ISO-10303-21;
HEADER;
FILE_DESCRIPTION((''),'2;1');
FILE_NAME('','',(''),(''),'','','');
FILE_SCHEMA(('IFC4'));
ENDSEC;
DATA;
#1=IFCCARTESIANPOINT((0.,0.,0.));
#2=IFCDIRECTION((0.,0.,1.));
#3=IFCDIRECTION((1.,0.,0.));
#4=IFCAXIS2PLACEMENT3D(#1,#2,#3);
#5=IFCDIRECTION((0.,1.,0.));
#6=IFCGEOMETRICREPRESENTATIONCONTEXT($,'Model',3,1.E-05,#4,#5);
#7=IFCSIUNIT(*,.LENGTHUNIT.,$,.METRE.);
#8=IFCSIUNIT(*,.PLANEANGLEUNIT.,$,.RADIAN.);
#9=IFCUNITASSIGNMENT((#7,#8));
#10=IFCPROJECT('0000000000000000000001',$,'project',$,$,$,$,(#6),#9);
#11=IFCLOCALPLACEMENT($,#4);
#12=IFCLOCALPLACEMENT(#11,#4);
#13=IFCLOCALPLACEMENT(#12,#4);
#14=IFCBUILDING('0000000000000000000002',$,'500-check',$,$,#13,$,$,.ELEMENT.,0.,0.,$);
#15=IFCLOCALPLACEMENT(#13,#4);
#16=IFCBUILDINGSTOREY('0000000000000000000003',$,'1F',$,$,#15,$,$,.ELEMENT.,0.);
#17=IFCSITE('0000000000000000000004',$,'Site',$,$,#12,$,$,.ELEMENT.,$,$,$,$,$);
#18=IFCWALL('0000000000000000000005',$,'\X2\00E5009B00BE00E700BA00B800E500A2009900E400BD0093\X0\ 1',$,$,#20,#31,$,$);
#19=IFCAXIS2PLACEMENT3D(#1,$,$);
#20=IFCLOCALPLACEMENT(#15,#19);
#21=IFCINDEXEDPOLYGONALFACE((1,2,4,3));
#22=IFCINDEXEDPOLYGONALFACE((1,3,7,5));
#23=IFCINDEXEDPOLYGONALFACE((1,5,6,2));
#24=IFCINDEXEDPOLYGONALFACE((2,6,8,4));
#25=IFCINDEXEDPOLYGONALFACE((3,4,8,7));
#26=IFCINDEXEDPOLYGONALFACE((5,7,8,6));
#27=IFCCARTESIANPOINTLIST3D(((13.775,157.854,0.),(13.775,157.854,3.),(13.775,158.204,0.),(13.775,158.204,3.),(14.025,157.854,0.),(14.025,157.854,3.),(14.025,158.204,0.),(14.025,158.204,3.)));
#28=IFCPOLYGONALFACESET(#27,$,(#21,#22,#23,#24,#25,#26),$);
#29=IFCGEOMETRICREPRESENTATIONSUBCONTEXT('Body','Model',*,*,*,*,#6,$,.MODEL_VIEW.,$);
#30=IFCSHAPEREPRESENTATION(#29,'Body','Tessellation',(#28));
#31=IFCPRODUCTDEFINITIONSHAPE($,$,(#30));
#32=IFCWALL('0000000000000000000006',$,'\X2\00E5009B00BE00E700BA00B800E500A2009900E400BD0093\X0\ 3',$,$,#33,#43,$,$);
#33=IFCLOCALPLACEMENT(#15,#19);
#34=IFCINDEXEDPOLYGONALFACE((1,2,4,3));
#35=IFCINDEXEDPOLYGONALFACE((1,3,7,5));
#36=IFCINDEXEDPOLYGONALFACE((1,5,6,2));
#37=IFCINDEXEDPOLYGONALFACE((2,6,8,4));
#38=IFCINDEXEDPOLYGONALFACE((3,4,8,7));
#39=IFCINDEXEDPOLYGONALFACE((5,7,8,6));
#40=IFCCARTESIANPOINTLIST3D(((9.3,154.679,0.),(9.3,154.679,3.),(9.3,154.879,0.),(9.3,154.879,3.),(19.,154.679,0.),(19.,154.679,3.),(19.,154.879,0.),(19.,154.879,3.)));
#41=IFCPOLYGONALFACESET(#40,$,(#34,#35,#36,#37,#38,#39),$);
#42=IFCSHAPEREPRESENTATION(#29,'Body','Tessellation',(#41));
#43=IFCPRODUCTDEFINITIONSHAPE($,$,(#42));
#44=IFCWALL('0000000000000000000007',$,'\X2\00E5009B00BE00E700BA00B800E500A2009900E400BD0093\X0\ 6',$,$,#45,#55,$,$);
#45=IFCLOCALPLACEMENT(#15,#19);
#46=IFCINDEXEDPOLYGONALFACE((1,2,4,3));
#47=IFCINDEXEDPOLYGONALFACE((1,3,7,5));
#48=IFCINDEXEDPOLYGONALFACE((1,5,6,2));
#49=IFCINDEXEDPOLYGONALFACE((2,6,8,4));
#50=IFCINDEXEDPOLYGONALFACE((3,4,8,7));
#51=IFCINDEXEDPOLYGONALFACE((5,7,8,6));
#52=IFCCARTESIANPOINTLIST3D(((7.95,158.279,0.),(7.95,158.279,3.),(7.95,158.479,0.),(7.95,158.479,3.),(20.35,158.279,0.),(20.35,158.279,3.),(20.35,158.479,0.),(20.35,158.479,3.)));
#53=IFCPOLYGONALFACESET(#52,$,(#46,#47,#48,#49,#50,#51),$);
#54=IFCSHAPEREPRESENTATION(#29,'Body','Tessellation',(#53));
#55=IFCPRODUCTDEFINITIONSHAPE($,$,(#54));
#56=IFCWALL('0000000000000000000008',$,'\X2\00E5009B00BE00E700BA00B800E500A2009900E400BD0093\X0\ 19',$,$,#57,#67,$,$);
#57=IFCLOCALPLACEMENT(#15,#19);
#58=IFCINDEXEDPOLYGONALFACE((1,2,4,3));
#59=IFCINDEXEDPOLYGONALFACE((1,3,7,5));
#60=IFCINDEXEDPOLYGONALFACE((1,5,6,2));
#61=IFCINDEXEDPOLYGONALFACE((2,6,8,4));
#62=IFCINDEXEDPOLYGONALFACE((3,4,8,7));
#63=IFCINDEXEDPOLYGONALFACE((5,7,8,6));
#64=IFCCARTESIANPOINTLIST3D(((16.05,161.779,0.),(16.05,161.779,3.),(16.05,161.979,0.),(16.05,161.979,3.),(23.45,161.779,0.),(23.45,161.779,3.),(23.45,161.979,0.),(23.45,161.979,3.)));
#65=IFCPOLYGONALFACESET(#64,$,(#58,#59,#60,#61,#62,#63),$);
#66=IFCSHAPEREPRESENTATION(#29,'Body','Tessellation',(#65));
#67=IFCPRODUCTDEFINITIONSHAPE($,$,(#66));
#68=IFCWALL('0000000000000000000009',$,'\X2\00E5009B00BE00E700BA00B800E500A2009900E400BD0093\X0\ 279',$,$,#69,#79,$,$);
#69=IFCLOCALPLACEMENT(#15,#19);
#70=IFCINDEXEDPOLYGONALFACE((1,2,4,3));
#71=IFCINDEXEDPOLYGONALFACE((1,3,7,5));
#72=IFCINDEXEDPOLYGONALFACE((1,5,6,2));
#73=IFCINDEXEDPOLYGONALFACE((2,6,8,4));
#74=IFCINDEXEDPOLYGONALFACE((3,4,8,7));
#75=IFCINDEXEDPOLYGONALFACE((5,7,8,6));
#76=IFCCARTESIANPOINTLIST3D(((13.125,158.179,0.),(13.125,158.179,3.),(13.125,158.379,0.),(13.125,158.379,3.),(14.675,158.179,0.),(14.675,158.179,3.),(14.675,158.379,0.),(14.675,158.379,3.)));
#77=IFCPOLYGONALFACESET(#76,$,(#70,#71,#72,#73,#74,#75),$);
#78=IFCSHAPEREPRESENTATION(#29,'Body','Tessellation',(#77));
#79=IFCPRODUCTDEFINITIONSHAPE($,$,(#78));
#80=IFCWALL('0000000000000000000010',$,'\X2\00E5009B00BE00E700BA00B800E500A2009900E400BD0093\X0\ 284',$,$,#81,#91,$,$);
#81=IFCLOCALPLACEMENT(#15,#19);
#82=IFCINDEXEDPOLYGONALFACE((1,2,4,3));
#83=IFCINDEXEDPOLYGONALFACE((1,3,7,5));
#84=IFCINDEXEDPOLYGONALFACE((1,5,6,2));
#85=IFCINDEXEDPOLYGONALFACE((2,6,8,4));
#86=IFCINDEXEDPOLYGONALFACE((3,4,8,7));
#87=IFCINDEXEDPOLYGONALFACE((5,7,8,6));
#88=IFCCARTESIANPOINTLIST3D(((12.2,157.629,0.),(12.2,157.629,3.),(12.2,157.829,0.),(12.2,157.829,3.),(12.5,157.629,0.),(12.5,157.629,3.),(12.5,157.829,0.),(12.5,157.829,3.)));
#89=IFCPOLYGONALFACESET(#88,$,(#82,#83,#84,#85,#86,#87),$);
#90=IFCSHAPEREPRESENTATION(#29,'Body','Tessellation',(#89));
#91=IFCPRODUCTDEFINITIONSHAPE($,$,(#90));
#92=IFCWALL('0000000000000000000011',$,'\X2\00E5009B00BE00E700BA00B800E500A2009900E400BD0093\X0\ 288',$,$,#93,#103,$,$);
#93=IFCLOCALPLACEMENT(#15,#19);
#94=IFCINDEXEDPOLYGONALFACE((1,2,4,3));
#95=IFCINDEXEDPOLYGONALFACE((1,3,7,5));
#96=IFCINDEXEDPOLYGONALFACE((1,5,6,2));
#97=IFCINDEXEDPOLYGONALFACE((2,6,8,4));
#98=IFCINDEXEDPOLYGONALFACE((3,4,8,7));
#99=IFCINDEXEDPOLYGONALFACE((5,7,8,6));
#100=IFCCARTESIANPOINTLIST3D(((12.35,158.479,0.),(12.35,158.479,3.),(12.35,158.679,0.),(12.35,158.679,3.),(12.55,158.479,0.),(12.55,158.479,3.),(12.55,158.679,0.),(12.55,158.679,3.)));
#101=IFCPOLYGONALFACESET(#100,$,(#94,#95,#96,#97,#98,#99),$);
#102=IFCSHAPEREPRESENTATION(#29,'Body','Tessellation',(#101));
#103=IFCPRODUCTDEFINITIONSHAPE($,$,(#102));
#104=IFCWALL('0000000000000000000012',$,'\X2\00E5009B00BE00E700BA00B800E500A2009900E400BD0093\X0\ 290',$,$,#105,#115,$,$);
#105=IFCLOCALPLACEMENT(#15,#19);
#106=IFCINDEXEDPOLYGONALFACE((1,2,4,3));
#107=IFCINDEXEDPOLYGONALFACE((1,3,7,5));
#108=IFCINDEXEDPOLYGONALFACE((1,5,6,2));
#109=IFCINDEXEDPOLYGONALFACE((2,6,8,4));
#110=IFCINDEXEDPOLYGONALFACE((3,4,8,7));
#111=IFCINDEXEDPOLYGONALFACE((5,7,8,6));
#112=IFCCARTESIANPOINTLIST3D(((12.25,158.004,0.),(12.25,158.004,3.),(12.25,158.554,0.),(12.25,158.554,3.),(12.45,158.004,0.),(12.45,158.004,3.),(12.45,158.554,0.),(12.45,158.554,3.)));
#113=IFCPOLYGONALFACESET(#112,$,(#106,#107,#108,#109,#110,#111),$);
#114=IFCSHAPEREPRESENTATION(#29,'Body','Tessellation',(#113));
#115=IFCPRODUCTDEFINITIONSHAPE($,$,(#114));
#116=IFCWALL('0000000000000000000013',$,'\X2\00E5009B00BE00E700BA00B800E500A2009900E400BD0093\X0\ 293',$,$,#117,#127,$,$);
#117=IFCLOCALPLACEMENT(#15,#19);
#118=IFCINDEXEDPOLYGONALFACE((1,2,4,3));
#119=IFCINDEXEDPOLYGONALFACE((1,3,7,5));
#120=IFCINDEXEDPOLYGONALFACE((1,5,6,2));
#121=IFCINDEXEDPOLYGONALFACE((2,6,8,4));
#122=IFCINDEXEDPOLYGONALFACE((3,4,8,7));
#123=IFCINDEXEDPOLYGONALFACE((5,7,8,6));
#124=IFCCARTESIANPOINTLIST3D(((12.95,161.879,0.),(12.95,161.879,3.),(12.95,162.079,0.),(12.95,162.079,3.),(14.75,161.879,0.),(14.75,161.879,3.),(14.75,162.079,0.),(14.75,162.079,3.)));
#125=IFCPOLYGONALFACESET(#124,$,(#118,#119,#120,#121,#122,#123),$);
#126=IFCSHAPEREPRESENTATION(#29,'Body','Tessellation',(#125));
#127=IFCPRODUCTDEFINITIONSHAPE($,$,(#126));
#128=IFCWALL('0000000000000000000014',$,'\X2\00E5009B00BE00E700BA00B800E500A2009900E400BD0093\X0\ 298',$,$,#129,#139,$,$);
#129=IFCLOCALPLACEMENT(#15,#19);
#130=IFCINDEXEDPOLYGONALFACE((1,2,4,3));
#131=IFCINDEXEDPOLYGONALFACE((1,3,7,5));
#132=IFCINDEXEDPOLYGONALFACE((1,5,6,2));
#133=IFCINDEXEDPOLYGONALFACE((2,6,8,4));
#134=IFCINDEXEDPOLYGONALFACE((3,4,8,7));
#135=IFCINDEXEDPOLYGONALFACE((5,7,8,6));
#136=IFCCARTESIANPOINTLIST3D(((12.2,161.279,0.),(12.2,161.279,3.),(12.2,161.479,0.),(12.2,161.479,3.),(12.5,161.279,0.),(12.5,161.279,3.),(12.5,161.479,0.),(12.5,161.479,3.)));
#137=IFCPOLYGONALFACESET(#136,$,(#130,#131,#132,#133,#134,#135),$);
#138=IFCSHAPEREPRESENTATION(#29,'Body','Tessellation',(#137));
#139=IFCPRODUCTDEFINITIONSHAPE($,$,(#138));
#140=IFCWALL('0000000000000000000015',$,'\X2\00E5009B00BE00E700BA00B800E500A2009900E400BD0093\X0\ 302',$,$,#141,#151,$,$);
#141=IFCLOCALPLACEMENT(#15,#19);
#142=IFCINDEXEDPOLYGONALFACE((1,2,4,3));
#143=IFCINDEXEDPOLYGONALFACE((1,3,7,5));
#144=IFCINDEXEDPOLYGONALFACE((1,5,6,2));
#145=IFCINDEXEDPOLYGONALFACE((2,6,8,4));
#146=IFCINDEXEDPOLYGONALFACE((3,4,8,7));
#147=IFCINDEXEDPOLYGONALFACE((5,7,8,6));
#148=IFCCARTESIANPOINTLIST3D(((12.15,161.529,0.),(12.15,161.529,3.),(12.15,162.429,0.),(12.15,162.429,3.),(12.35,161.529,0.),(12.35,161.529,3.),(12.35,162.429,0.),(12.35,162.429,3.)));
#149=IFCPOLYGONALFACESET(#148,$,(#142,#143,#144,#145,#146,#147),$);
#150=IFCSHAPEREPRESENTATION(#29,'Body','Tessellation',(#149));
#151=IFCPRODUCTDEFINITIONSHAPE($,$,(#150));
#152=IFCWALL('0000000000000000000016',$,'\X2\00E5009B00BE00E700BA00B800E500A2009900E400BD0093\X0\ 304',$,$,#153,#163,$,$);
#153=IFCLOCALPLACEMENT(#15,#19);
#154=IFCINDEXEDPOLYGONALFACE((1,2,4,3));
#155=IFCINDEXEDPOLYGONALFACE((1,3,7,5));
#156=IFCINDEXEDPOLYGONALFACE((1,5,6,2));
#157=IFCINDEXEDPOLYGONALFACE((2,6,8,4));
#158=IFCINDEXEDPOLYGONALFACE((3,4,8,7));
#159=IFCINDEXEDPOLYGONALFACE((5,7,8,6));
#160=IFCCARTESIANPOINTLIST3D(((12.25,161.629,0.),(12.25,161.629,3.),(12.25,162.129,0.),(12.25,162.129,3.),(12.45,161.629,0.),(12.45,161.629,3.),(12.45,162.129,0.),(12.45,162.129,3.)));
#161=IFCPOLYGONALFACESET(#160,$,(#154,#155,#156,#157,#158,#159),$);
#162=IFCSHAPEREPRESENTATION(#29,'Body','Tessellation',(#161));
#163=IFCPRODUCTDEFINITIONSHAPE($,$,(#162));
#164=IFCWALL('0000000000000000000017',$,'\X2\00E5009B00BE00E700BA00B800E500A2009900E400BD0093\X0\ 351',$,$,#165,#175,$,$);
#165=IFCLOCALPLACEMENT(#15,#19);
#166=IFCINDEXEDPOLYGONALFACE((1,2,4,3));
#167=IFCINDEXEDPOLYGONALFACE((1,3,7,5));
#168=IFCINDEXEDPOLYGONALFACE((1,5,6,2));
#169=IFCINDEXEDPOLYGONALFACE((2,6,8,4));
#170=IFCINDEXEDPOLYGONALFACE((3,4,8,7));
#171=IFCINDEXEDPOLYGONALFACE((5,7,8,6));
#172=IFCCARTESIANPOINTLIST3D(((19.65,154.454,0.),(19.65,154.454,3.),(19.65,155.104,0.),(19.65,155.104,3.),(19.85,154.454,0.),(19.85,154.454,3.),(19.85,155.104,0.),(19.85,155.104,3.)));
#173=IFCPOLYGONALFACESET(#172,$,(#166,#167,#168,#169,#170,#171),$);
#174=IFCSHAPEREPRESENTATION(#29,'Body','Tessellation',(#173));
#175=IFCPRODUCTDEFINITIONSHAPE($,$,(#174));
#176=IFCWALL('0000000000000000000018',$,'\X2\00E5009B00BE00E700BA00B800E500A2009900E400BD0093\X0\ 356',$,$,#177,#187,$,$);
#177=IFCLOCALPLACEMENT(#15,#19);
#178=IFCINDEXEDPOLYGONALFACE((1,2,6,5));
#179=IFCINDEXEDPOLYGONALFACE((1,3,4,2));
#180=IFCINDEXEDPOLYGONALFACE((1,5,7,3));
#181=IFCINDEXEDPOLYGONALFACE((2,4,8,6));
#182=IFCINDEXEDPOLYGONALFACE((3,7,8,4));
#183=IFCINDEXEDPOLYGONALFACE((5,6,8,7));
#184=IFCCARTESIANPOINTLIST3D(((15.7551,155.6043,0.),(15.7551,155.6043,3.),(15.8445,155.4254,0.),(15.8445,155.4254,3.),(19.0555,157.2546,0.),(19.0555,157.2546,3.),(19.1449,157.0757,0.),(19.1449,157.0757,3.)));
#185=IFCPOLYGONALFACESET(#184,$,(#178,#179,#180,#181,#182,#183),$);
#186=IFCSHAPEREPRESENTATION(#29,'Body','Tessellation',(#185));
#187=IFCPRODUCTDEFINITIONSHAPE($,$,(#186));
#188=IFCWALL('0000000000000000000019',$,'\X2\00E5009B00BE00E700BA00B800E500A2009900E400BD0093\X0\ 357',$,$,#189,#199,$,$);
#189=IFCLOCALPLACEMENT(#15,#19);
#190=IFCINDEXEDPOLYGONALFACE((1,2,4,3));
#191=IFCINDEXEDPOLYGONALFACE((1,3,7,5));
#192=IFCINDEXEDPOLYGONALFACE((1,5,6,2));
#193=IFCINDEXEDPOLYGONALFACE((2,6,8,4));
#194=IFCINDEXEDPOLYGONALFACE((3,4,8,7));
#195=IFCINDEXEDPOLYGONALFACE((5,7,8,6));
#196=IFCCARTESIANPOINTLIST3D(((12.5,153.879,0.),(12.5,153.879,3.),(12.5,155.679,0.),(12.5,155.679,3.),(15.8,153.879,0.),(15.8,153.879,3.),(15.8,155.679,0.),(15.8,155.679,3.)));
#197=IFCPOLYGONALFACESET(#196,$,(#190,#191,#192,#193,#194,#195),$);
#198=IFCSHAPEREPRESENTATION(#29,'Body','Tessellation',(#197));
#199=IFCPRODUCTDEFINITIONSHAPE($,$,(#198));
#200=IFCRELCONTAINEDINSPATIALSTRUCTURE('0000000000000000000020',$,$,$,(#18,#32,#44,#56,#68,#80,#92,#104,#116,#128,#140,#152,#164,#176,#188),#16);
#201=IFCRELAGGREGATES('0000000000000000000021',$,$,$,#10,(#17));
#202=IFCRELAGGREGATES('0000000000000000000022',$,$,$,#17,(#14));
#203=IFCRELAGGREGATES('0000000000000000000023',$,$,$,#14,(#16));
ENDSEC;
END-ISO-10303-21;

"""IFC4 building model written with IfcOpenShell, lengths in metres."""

from ifc_helpers import new_model, si_unit, direction, frame, frame_2d, origin_with_axes, place, context, subcontext, project, spatial, rectangle, extrude, element, save


model = new_model("IFC4")

# Units and contexts
model_context = context("Model", 3, precision=1e-05, world=origin_with_axes(), true_north=direction((0.0, 1.0, 0.0)))
body_context = subcontext(model_context, "Body", "Model", "MODEL_VIEW")
ifc_project = project(units=[si_unit("LENGTHUNIT", "METRE"), si_unit("PLANEANGLEUNIT", "RADIAN")], contexts=[model_context])

# Site, building, storey
placement = place(None, origin_with_axes())
site_placement = place(placement, origin_with_axes())
site = spatial("IfcSite", under=ifc_project, at=site_placement, Name="Site", CompositionType="ELEMENT")
building_placement = place(site_placement, origin_with_axes())
building = spatial("IfcBuilding", under=site, at=building_placement, Name="500-check", CompositionType="ELEMENT", ElevationOfRefHeight=0.0, ElevationOfTerrain=0.0)
storey_placement = place(building_placement, origin_with_axes())
storey = spatial("IfcBuildingStorey", under=building, at=storey_placement, Name="1F", CompositionType="ELEMENT", Elevation=0.0)

# Walls
wall_1_placement = place(storey_placement, frame((13.9, 158.029, 0.0), z_axis=(0.0, 0.0, 1.0), x_axis=(1.0, 0.0, 0.0)))
element("IfcWall", 1, at=wall_1_placement, inside=storey, Name="å\u009b¾çº¸å¢\u0099ä½\u0093 1", context=body_context, shape_type="SweptSolid", body=[
    extrude(rectangle(XDim=0.25, YDim=0.35, at=frame_2d((0.0, 0.0), x_axis=(1.0, 0.0, 0.0))), frame((0.0, 0.0, 0.0), z_axis=(0.0, 0.0, 1.0)), (0.0, 0.0, 1.0), 3.0),
])
for number, where, z_axis, x_axis, name in (
    (2, (14.15, 154.779, 0.0), (0.0, 0.0, 1.0), (-1.0, 0.0, 0.0), "å\u009b¾çº¸å¢\u0099ä½\u0093 3"),
):
    element("IfcWall", number, at=place(storey_placement, frame(where, z_axis=z_axis, x_axis=x_axis)), inside=storey, Name=name, context=body_context, shape_type="SweptSolid", body=[
        extrude(rectangle(XDim=9.7, YDim=0.2, at=frame_2d((0.0, 0.0), x_axis=(1.0, 0.0, 0.0))), frame((0.0, 0.0, 0.0), z_axis=(0.0, 0.0, 1.0)), (0.0, 0.0, 1.0), 3.0),
    ])
wall_2_placement = place(storey_placement, frame((14.15, 158.379, 0.0), z_axis=(0.0, 0.0, 1.0), x_axis=(-1.0, 0.0, 0.0)))
element("IfcWall", 3, at=wall_2_placement, inside=storey, Name="å\u009b¾çº¸å¢\u0099ä½\u0093 6", context=body_context, shape_type="SweptSolid", body=[
    extrude(rectangle(XDim=12.4, YDim=0.2, at=frame_2d((0.0, 0.0), x_axis=(1.0, 0.0, 0.0))), frame((0.0, 0.0, 0.0), z_axis=(0.0, 0.0, 1.0)), (0.0, 0.0, 1.0), 3.0),
])
wall_3_placement = place(storey_placement, frame((19.75, 161.879, 0.0), z_axis=(0.0, 0.0, 1.0), x_axis=(-1.0, 0.0, 0.0)))
element("IfcWall", 4, at=wall_3_placement, inside=storey, Name="å\u009b¾çº¸å¢\u0099ä½\u0093 19", context=body_context, shape_type="SweptSolid", body=[
    extrude(rectangle(XDim=7.4, YDim=0.2, at=frame_2d((0.0, 0.0), x_axis=(1.0, 0.0, 0.0))), frame((0.0, 0.0, 0.0), z_axis=(0.0, 0.0, 1.0)), (0.0, 0.0, 1.0), 3.0),
])
wall_4_placement = place(storey_placement, frame((13.9, 158.279, 0.0), z_axis=(0.0, 0.0, 1.0), x_axis=(-1.0, 0.0, 0.0)))
element("IfcWall", 5, at=wall_4_placement, inside=storey, Name="å\u009b¾çº¸å¢\u0099ä½\u0093 279", context=body_context, shape_type="SweptSolid", body=[
    extrude(rectangle(XDim=1.55, YDim=0.2, at=frame_2d((0.0, 0.0), x_axis=(1.0, 0.0, 0.0))), frame((0.0, 0.0, 0.0), z_axis=(0.0, 0.0, 1.0)), (0.0, 0.0, 1.0), 3.0),
])
wall_5_placement = place(storey_placement, frame((12.35, 157.729, 0.0), z_axis=(0.0, 0.0, 1.0), x_axis=(-1.0, 0.0, 0.0)))
element("IfcWall", 6, at=wall_5_placement, inside=storey, Name="å\u009b¾çº¸å¢\u0099ä½\u0093 284", context=body_context, shape_type="SweptSolid", body=[
    extrude(rectangle(XDim=0.3, YDim=0.2, at=frame_2d((0.0, 0.0), x_axis=(1.0, 0.0, 0.0))), frame((0.0, 0.0, 0.0), z_axis=(0.0, 0.0, 1.0)), (0.0, 0.0, 1.0), 3.0),
])
for number, where, z_axis, x_axis, name in (
    (7, (12.45, 158.579, 0.0), (0.0, 0.0, 1.0), (-1.0, 0.0, 0.0), "å\u009b¾çº¸å¢\u0099ä½\u0093 288"),
):
    element("IfcWall", number, at=place(storey_placement, frame(where, z_axis=z_axis, x_axis=x_axis)), inside=storey, Name=name, context=body_context, shape_type="SweptSolid", body=[
        extrude(rectangle(XDim=0.2, YDim=0.2, at=frame_2d((0.0, 0.0), x_axis=(1.0, 0.0, 0.0))), frame((0.0, 0.0, 0.0), z_axis=(0.0, 0.0, 1.0)), (0.0, 0.0, 1.0), 3.0),
    ])
wall_6_placement = place(storey_placement, frame((12.35, 158.279, 0.0), z_axis=(0.0, 0.0, 1.0), x_axis=(0.0, -1.0, 0.0)))
element("IfcWall", 8, at=wall_6_placement, inside=storey, Name="å\u009b¾çº¸å¢\u0099ä½\u0093 290", context=body_context, shape_type="SweptSolid", body=[
    extrude(rectangle(XDim=0.55, YDim=0.2, at=frame_2d((0.0, 0.0), x_axis=(1.0, 0.0, 0.0))), frame((0.0, 0.0, 0.0), z_axis=(0.0, 0.0, 1.0)), (0.0, 0.0, 1.0), 3.0),
])
wall_7_placement = place(storey_placement, frame((13.85, 161.979, 0.0), z_axis=(0.0, 0.0, 1.0), x_axis=(-1.0, 0.0, 0.0)))
element("IfcWall", 9, at=wall_7_placement, inside=storey, Name="å\u009b¾çº¸å¢\u0099ä½\u0093 293", context=body_context, shape_type="SweptSolid", body=[
    extrude(rectangle(XDim=1.8, YDim=0.2, at=frame_2d((0.0, 0.0), x_axis=(1.0, 0.0, 0.0))), frame((0.0, 0.0, 0.0), z_axis=(0.0, 0.0, 1.0)), (0.0, 0.0, 1.0), 3.0),
])
wall_8_placement = place(storey_placement, frame((12.35, 161.379, 0.0), z_axis=(0.0, 0.0, 1.0), x_axis=(-1.0, 0.0, 0.0)))
element("IfcWall", 10, at=wall_8_placement, inside=storey, Name="å\u009b¾çº¸å¢\u0099ä½\u0093 298", context=body_context, shape_type="SweptSolid", body=[
    extrude(rectangle(XDim=0.3, YDim=0.2, at=frame_2d((0.0, 0.0), x_axis=(1.0, 0.0, 0.0))), frame((0.0, 0.0, 0.0), z_axis=(0.0, 0.0, 1.0)), (0.0, 0.0, 1.0), 3.0),
])
wall_9_placement = place(storey_placement, frame((12.25, 161.979, 0.0), z_axis=(0.0, 0.0, 1.0), x_axis=(0.0, 1.0, 0.0)))
element("IfcWall", 11, at=wall_9_placement, inside=storey, Name="å\u009b¾çº¸å¢\u0099ä½\u0093 302", context=body_context, shape_type="SweptSolid", body=[
    extrude(rectangle(XDim=0.9, YDim=0.2, at=frame_2d((0.0, 0.0), x_axis=(1.0, 0.0, 0.0))), frame((0.0, 0.0, 0.0), z_axis=(0.0, 0.0, 1.0)), (0.0, 0.0, 1.0), 3.0),
])
wall_10_placement = place(storey_placement, frame((12.35, 161.879, 0.0), z_axis=(0.0, 0.0, 1.0), x_axis=(0.0, -1.0, 0.0)))
element("IfcWall", 12, at=wall_10_placement, inside=storey, Name="å\u009b¾çº¸å¢\u0099ä½\u0093 304", context=body_context, shape_type="SweptSolid", body=[
    extrude(rectangle(XDim=0.5, YDim=0.2, at=frame_2d((0.0, 0.0), x_axis=(1.0, 0.0, 0.0))), frame((0.0, 0.0, 0.0), z_axis=(0.0, 0.0, 1.0)), (0.0, 0.0, 1.0), 3.0),
])
wall_11_placement = place(storey_placement, frame((19.75, 154.779, 0.0), z_axis=(0.0, 0.0, 1.0), x_axis=(0.0, -1.0, 0.0)))
element("IfcWall", 13, at=wall_11_placement, inside=storey, Name="å\u009b¾çº¸å¢\u0099ä½\u0093 351", context=body_context, shape_type="SweptSolid", body=[
    extrude(rectangle(XDim=0.65, YDim=0.2, at=frame_2d((0.0, 0.0), x_axis=(1.0, 0.0, 0.0))), frame((0.0, 0.0, 0.0), z_axis=(0.0, 0.0, 1.0)), (0.0, 0.0, 1.0), 3.0),
])
wall_12_placement = place(storey_placement, frame((17.45, 156.34, 0.0), z_axis=(0.0, 0.0, 1.0), x_axis=(-0.894428, -0.447213, 0.0)))
element("IfcWall", 14, at=wall_12_placement, inside=storey, Name="å\u009b¾çº¸å¢\u0099ä½\u0093 356", context=body_context, shape_type="SweptSolid", body=[
    extrude(rectangle(XDim=3.69, YDim=0.2, at=frame_2d((0.0, 0.0), x_axis=(1.0, 0.0, 0.0))), frame((0.0, 0.0, 0.0), z_axis=(0.0, 0.0, 1.0)), (0.0, 0.0, 1.0), 3.0),
])
wall_13_placement = place(storey_placement, frame((14.15, 154.779, 0.0), z_axis=(0.0, 0.0, 1.0), x_axis=(1.0, 0.0, 0.0)))
element("IfcWall", 15, at=wall_13_placement, inside=storey, Name="å\u009b¾çº¸å¢\u0099ä½\u0093 357", context=body_context, shape_type="SweptSolid", body=[
    extrude(rectangle(XDim=3.3, YDim=1.8, at=frame_2d((0.0, 0.0), x_axis=(1.0, 0.0, 0.0))), frame((0.0, 0.0, 0.0), z_axis=(0.0, 0.0, 1.0)), (0.0, 0.0, 1.0), 3.0),
])

save(model, "model.ifc")
